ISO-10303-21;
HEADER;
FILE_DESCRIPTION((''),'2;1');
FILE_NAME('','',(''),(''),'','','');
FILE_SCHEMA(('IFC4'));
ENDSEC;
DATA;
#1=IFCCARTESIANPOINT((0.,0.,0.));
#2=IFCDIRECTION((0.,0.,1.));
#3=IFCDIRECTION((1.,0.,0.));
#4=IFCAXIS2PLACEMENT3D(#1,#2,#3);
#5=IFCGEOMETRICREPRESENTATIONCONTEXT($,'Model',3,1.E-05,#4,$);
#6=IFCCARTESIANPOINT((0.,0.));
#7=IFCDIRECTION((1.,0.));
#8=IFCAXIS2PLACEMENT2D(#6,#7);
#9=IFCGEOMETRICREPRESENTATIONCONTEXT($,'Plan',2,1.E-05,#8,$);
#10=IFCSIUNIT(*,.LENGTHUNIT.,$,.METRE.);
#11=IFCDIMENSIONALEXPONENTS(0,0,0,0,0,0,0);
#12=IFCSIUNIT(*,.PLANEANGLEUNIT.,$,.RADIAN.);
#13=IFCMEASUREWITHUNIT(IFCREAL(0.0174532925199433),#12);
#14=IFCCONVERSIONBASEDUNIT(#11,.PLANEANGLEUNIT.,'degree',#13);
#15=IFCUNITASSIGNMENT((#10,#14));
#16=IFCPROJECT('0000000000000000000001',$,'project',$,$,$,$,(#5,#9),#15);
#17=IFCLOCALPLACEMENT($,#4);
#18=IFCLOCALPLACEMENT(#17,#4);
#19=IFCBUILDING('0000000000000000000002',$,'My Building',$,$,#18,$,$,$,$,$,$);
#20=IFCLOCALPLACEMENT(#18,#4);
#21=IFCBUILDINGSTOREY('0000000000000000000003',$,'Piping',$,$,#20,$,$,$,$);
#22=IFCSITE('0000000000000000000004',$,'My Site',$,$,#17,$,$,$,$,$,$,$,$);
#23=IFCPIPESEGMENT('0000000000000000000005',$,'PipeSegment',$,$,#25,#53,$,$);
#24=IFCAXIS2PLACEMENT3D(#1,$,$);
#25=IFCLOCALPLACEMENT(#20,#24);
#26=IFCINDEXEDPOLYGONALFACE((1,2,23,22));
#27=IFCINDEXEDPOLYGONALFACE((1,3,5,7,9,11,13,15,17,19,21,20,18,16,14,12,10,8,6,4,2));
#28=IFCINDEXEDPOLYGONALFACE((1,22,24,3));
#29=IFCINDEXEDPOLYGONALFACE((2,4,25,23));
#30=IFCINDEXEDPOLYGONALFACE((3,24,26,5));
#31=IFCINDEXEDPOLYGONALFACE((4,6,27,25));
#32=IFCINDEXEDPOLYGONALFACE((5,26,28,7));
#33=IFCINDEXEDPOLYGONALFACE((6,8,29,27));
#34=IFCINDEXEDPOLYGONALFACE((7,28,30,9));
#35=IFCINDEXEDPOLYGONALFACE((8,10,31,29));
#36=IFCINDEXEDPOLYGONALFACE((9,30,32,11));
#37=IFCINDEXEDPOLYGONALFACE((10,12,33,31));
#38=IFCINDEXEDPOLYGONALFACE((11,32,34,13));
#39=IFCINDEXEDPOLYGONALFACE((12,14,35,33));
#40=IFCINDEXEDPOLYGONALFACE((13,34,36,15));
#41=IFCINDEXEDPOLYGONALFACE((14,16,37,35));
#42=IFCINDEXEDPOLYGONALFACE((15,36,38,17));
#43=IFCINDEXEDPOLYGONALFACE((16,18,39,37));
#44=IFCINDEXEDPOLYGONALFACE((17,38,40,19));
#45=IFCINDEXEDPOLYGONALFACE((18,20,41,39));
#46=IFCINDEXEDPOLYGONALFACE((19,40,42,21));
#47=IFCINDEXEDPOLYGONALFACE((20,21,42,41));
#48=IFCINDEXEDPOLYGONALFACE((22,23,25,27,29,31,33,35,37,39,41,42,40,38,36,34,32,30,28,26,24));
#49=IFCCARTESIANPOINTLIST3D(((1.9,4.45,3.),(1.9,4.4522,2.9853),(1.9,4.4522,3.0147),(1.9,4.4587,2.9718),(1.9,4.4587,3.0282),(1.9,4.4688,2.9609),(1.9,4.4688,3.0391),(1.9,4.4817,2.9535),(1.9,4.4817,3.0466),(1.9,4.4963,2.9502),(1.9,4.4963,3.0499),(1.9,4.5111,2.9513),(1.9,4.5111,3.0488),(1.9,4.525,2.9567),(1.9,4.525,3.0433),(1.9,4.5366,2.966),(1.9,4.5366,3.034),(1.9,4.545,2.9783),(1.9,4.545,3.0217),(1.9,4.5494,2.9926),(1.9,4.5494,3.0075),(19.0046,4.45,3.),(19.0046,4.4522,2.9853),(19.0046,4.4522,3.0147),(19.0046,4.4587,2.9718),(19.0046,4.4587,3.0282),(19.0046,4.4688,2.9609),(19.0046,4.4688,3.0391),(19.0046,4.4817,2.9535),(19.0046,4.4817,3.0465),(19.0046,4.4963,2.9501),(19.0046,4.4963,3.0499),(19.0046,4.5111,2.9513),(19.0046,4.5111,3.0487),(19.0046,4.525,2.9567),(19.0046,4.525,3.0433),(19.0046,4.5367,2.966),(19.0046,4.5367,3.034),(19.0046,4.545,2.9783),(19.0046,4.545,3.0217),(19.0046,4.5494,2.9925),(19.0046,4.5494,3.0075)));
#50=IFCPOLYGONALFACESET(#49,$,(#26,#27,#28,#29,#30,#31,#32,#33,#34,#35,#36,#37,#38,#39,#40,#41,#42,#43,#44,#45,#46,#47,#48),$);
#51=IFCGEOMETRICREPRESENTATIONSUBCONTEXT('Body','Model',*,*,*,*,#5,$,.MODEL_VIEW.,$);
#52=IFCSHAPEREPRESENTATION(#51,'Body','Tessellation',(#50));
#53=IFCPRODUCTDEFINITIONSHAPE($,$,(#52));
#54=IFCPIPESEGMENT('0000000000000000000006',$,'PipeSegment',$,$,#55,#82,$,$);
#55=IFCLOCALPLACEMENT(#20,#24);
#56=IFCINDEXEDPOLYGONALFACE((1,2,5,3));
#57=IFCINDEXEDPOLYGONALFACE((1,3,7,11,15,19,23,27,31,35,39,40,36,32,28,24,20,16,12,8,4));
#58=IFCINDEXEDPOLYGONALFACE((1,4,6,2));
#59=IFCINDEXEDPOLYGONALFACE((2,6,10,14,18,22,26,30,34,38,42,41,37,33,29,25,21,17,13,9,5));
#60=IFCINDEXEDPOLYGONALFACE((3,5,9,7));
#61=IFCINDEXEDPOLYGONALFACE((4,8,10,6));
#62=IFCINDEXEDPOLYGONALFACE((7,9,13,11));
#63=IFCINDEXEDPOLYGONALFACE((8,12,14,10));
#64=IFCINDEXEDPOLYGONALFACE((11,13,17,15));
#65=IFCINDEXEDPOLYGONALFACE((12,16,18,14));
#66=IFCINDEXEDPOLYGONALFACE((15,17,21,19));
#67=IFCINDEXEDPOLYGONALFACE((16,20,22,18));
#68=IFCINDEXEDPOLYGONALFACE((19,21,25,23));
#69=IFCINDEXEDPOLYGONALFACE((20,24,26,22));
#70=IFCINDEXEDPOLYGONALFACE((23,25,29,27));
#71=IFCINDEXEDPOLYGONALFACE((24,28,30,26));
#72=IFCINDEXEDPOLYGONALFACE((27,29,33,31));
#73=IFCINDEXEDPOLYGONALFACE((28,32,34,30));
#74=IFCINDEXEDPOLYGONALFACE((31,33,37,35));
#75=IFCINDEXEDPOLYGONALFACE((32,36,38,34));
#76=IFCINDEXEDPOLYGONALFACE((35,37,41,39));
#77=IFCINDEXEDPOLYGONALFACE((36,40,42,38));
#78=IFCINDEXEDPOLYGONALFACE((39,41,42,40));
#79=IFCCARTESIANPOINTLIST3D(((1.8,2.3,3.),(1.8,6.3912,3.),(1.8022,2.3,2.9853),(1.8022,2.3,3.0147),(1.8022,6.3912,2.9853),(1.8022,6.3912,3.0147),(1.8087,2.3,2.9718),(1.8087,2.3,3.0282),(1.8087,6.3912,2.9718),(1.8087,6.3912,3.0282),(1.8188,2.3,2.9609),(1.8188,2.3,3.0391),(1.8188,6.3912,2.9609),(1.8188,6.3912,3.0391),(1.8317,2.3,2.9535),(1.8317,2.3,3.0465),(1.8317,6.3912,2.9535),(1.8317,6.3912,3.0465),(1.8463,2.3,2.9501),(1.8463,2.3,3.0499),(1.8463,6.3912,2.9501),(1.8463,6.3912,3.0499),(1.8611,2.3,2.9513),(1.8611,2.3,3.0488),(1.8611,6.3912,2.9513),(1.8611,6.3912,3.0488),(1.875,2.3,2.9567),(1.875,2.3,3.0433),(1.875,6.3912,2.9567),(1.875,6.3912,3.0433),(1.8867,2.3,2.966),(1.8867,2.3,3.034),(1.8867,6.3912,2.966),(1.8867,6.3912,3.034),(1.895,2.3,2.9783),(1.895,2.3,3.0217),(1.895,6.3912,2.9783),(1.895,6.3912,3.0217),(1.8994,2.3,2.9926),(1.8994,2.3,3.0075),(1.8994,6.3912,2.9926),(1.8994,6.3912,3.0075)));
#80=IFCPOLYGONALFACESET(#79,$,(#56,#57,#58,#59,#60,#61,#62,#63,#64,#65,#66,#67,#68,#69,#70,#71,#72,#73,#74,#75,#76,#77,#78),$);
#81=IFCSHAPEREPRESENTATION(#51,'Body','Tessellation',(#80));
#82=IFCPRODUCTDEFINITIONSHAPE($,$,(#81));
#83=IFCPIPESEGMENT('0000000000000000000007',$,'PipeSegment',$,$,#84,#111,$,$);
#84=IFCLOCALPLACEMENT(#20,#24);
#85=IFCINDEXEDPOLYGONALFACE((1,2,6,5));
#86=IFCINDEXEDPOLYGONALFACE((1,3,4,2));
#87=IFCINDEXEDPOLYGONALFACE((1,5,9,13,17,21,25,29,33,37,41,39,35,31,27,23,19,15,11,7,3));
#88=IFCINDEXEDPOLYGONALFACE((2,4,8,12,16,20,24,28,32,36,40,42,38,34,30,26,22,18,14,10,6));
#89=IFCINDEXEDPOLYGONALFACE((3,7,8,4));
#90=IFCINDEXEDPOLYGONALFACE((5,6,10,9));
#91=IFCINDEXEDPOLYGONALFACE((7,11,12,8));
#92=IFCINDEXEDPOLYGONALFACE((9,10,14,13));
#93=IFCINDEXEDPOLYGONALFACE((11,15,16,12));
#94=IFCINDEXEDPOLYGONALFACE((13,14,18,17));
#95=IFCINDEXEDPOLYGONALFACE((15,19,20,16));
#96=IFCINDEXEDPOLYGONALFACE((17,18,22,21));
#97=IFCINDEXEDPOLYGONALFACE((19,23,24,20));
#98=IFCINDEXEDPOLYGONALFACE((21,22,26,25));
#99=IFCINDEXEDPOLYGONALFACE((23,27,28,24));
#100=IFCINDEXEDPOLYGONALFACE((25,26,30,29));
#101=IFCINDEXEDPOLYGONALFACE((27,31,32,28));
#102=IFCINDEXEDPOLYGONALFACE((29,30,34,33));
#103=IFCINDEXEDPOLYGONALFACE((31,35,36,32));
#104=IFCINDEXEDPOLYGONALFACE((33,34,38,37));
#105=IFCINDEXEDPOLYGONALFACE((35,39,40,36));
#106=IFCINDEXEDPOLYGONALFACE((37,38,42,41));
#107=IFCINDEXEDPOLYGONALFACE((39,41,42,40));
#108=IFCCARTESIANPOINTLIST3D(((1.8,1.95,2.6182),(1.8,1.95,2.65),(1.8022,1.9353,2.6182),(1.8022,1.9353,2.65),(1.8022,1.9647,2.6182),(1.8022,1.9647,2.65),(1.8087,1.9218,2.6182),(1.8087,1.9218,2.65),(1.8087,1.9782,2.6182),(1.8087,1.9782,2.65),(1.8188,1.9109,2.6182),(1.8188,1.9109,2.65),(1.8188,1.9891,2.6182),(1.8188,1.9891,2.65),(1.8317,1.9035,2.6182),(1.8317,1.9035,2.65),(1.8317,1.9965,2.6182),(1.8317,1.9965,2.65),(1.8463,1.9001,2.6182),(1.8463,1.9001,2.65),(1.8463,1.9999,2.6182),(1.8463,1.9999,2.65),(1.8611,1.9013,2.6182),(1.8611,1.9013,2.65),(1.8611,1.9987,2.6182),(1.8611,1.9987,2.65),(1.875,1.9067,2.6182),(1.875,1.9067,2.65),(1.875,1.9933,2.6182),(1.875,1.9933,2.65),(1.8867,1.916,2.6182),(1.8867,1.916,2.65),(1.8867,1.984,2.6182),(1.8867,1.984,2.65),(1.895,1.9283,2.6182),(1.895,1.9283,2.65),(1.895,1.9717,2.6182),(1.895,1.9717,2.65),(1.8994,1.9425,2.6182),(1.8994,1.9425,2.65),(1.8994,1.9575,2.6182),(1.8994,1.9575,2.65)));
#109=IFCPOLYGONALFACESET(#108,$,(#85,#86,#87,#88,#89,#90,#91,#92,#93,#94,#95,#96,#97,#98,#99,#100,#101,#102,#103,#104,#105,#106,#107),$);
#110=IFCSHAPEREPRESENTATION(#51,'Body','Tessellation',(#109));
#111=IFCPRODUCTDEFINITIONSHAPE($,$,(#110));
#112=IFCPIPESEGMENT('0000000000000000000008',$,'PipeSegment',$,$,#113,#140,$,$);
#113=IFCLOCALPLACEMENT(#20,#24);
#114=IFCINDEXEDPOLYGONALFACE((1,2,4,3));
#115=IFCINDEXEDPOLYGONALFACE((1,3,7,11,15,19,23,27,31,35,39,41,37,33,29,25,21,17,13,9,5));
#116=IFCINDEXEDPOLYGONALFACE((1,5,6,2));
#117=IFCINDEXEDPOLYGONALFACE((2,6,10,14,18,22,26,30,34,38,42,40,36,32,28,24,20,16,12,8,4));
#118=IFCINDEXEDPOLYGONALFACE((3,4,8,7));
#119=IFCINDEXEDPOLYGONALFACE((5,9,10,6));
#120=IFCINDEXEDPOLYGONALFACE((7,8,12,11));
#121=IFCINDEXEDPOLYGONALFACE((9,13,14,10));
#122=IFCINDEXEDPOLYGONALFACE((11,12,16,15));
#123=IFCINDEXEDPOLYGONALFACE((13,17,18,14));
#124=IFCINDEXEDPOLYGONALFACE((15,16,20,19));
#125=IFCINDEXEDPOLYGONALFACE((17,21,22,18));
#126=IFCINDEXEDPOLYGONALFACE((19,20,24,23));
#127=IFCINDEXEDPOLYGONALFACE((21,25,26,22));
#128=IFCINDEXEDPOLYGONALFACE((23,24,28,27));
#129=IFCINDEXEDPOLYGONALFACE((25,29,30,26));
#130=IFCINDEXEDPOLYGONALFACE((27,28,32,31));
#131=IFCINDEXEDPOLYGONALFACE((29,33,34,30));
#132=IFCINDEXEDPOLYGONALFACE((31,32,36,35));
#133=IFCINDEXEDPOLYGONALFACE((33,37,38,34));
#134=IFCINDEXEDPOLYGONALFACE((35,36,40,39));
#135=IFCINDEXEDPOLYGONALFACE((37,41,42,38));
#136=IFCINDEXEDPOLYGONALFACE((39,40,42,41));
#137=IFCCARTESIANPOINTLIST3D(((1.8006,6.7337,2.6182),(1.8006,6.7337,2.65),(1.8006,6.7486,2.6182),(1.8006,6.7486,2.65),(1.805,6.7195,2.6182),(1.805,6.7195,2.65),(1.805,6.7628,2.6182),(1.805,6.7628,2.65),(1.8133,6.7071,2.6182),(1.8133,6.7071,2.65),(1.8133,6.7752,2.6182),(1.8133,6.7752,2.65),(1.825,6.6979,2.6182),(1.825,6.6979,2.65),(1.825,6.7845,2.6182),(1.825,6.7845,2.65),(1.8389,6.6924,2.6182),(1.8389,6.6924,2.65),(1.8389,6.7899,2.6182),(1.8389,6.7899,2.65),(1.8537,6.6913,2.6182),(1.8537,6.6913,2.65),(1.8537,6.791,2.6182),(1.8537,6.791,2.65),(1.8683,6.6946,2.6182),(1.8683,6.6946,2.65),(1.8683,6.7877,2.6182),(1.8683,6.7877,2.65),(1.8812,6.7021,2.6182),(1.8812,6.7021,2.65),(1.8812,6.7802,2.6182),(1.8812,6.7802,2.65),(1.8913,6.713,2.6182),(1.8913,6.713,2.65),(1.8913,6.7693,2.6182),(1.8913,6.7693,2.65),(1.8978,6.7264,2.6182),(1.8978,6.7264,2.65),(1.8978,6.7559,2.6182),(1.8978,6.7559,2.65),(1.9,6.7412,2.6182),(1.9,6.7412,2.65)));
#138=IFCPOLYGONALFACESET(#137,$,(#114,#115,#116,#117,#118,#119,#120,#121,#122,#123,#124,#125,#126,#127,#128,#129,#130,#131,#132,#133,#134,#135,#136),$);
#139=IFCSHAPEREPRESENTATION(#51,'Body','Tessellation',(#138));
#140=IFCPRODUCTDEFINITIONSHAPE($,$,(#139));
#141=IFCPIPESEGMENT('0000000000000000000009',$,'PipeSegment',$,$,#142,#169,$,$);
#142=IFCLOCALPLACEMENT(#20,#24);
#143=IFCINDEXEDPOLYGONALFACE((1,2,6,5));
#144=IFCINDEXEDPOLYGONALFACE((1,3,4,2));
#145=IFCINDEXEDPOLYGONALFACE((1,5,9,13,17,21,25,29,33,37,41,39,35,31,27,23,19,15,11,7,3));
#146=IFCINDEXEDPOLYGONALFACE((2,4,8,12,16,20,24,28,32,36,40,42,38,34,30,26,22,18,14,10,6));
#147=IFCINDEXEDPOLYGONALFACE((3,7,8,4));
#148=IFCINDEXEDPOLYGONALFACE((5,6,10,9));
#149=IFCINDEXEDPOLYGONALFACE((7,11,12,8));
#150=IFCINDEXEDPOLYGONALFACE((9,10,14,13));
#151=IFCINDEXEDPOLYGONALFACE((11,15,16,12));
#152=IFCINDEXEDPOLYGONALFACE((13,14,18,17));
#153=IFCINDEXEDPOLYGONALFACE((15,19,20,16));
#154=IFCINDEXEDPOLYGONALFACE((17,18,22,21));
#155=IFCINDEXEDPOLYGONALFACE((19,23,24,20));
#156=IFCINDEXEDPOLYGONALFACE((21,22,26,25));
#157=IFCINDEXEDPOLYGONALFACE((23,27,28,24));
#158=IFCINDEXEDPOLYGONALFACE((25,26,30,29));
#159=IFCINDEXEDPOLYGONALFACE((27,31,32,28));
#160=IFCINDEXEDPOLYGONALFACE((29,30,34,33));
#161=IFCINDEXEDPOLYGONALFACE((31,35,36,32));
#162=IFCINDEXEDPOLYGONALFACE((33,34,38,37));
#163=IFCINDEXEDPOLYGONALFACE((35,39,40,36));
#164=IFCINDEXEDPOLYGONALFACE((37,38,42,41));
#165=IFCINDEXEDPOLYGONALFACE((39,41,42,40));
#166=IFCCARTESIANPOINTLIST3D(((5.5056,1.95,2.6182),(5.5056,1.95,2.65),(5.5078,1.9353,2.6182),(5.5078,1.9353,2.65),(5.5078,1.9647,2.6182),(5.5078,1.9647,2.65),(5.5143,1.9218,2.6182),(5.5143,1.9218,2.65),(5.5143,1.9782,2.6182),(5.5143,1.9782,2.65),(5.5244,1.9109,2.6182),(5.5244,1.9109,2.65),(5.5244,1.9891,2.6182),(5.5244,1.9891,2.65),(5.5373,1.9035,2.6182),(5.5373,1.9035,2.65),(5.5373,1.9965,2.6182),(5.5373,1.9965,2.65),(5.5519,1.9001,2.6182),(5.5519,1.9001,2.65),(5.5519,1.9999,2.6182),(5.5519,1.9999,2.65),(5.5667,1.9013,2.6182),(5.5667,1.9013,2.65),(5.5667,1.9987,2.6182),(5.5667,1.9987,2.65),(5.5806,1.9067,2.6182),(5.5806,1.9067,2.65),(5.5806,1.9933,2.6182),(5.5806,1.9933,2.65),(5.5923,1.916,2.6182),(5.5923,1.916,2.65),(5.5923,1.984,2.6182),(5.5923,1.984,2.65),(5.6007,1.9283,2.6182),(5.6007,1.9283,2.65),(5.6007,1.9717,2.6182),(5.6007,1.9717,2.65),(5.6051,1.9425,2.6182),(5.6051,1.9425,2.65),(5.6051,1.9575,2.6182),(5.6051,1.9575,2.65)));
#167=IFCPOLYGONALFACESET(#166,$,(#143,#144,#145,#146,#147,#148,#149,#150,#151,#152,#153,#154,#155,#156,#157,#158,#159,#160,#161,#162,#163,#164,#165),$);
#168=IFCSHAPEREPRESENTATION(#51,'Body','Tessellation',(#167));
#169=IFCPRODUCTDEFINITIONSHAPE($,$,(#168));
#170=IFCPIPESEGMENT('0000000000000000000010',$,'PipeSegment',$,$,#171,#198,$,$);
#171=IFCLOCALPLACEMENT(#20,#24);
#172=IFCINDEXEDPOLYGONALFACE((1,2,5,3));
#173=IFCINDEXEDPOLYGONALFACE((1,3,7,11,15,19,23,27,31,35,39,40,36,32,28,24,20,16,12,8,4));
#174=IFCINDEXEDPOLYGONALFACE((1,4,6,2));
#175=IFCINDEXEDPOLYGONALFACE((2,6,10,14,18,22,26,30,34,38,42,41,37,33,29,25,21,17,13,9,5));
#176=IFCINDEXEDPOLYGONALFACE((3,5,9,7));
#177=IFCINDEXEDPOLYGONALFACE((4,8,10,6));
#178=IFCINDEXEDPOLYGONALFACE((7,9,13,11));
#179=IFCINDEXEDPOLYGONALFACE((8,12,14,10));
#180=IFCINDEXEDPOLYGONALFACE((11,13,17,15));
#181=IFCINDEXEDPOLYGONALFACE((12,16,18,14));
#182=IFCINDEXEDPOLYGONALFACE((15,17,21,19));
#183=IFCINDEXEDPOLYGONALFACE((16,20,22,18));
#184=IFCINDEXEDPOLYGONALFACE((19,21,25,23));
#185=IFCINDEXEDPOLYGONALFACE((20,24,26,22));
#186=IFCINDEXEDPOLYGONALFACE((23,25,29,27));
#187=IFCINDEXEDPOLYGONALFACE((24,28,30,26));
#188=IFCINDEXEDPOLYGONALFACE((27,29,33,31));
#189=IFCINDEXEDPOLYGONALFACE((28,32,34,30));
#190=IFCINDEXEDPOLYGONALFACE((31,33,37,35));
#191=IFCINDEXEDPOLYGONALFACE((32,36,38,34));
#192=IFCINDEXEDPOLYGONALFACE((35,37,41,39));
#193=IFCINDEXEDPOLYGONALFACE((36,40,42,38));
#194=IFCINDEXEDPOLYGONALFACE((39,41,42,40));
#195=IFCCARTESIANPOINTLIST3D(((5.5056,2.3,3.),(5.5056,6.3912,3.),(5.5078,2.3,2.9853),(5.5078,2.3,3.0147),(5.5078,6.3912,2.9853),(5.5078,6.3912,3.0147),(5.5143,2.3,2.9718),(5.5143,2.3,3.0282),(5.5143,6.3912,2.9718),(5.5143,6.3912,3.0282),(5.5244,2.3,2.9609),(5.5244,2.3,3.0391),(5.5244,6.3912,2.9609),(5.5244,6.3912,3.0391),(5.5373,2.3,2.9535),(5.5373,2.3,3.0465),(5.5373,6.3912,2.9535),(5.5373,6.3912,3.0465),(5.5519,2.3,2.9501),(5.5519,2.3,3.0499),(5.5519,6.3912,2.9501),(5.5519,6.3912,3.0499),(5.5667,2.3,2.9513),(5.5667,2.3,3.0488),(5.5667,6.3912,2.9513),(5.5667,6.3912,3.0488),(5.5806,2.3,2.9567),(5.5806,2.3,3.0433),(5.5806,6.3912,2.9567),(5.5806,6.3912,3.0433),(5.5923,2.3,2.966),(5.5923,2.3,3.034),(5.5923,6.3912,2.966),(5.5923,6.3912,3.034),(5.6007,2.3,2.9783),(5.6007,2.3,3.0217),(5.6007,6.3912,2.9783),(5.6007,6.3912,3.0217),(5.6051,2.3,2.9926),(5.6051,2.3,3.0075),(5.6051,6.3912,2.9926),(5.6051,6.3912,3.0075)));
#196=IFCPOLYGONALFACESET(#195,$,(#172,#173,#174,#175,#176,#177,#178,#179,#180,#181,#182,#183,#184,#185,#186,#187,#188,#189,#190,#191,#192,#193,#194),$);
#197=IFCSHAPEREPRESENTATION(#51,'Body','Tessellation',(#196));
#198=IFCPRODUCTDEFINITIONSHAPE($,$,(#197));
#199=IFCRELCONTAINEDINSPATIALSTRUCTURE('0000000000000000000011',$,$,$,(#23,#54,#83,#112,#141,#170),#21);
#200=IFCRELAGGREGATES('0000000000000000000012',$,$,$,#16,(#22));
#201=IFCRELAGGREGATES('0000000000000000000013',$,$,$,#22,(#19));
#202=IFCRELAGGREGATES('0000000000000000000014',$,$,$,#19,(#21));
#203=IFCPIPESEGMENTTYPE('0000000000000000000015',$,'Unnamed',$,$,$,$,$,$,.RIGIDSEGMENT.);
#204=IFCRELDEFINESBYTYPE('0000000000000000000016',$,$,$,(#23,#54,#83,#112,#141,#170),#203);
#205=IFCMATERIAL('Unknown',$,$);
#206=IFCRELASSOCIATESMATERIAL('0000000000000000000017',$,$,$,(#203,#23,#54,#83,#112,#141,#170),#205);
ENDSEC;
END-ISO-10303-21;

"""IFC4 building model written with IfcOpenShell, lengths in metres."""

from ifc_helpers import new_model, entity, si_unit, converted_unit, frame, origin_with_axes, origin_2d_with_axis, place, context, subcontext, project, spatial, circle, extrude, material, material_profile, profile_set, profile_usage, type_object, element, save


model = new_model("IFC4")

# Units and contexts
model_context = context("Model", 3, precision=1e-05, world=origin_with_axes())
plan_context = context("Plan", 2, precision=1e-05, world=origin_2d_with_axis())
body_context = subcontext(model_context, "Body", "Model", "MODEL_VIEW")
ifc_project = project(units=[si_unit("LENGTHUNIT", "METRE"), converted_unit("PLANEANGLEUNIT", "degree", entity("IfcReal", 0.0174532925199433), si_unit("PLANEANGLEUNIT", "RADIAN"), dimensions=[0, 0, 0, 0, 0, 0, 0])], contexts=[model_context, plan_context])

# Site, building, storey
site_placement = place(None, origin_with_axes())
site = spatial("IfcSite", under=ifc_project, at=site_placement, Name="My Site")
building_placement = place(site_placement, origin_with_axes())
building = spatial("IfcBuilding", under=site, at=building_placement, Name="My Building")
storey_placement = place(building_placement, origin_with_axes())
storey = spatial("IfcBuildingStorey", under=building, at=storey_placement, Name="Piping")

# Pipe segments
ifc_material = material(Name="Unknown")
ifc_material_profile = material_profile(ifc_material, circle(Radius=0.05))
ifc_profile_set = profile_set([ifc_material_profile])
ifc_profile_usage_1 = profile_usage(ifc_profile_set, cardinal=5)
pipe_segment_type = type_object("IfcPipeSegmentType", Name="Unnamed", PredefinedType="RIGIDSEGMENT", material=ifc_profile_set)
pipe_segment_1_placement = place(storey_placement, frame((19.0046, 4.5, 3.0), z_axis=(-1.0, -0.000001, 0.000001), x_axis=(0.000001, -1.0, 0.0)))
element("IfcPipeSegment", 1, at=pipe_segment_1_placement, inside=storey, type_object=pipe_segment_type, material=ifc_profile_usage_1, Name="PipeSegment", context=body_context, shape_type="SweptSolid", body=[
    extrude(circle(Radius=0.05), origin_with_axes(), (0.0, 0.0, 1.0), 17.1046),
])
ifc_profile_usage_2 = profile_usage(ifc_profile_set, cardinal=5)
pipe_segment_2_placement = place(storey_placement, frame((1.85, 2.3, 3.0), z_axis=(0.0, 1.0, 0.0), x_axis=(-1.0, 0.0, 0.0)))
element("IfcPipeSegment", 2, at=pipe_segment_2_placement, inside=storey, type_object=pipe_segment_type, material=ifc_profile_usage_2, Name="PipeSegment", context=body_context, shape_type="SweptSolid", body=[
    extrude(circle(Radius=0.05), origin_with_axes(), (0.0, 0.0, 1.0), 4.0912),
])
ifc_profile_usage_3 = profile_usage(ifc_profile_set, cardinal=5)
pipe_segment_3_placement = place(storey_placement, frame((1.85, 1.95, 2.65), z_axis=(0.0, 0.0, -1.0), x_axis=(-1.0, 0.0, 0.0)))
element("IfcPipeSegment", 3, at=pipe_segment_3_placement, inside=storey, type_object=pipe_segment_type, material=ifc_profile_usage_3, Name="PipeSegment", context=body_context, shape_type="SweptSolid", body=[
    extrude(circle(Radius=0.05), origin_with_axes(), (0.0, 0.0, 1.0), 0.0318),
])
ifc_profile_usage_4 = profile_usage(ifc_profile_set, cardinal=5)
pipe_segment_4_placement = place(storey_placement, frame((1.85, 6.7412, 2.65), z_axis=(0.0, 0.0, -1.0), x_axis=(1.0, 0.0, 0.0)))
element("IfcPipeSegment", 4, at=pipe_segment_4_placement, inside=storey, type_object=pipe_segment_type, material=ifc_profile_usage_4, Name="PipeSegment", context=body_context, shape_type="SweptSolid", body=[
    extrude(circle(Radius=0.05), origin_with_axes(), (0.0, 0.0, 1.0), 0.0318),
])
ifc_profile_usage_5 = profile_usage(ifc_profile_set, cardinal=5)
pipe_segment_5_placement = place(storey_placement, frame((5.5556, 1.95, 2.65), z_axis=(0.0, 0.0, -1.0), x_axis=(-1.0, 0.0, 0.0)))
element("IfcPipeSegment", 5, at=pipe_segment_5_placement, inside=storey, type_object=pipe_segment_type, material=ifc_profile_usage_5, Name="PipeSegment", context=body_context, shape_type="SweptSolid", body=[
    extrude(circle(Radius=0.05), origin_with_axes(), (0.0, 0.0, 1.0), 0.0318),
])
ifc_profile_usage_6 = profile_usage(ifc_profile_set, cardinal=5)
pipe_segment_6_placement = place(storey_placement, frame((5.5556, 2.3, 3.0), z_axis=(0.0, 1.0, 0.0), x_axis=(-1.0, 0.0, 0.0)))
element("IfcPipeSegment", 6, at=pipe_segment_6_placement, inside=storey, type_object=pipe_segment_type, material=ifc_profile_usage_6, Name="PipeSegment", context=body_context, shape_type="SweptSolid", body=[
    extrude(circle(Radius=0.05), origin_with_axes(), (0.0, 0.0, 1.0), 4.0912),
])

save(model, "model.ifc")
